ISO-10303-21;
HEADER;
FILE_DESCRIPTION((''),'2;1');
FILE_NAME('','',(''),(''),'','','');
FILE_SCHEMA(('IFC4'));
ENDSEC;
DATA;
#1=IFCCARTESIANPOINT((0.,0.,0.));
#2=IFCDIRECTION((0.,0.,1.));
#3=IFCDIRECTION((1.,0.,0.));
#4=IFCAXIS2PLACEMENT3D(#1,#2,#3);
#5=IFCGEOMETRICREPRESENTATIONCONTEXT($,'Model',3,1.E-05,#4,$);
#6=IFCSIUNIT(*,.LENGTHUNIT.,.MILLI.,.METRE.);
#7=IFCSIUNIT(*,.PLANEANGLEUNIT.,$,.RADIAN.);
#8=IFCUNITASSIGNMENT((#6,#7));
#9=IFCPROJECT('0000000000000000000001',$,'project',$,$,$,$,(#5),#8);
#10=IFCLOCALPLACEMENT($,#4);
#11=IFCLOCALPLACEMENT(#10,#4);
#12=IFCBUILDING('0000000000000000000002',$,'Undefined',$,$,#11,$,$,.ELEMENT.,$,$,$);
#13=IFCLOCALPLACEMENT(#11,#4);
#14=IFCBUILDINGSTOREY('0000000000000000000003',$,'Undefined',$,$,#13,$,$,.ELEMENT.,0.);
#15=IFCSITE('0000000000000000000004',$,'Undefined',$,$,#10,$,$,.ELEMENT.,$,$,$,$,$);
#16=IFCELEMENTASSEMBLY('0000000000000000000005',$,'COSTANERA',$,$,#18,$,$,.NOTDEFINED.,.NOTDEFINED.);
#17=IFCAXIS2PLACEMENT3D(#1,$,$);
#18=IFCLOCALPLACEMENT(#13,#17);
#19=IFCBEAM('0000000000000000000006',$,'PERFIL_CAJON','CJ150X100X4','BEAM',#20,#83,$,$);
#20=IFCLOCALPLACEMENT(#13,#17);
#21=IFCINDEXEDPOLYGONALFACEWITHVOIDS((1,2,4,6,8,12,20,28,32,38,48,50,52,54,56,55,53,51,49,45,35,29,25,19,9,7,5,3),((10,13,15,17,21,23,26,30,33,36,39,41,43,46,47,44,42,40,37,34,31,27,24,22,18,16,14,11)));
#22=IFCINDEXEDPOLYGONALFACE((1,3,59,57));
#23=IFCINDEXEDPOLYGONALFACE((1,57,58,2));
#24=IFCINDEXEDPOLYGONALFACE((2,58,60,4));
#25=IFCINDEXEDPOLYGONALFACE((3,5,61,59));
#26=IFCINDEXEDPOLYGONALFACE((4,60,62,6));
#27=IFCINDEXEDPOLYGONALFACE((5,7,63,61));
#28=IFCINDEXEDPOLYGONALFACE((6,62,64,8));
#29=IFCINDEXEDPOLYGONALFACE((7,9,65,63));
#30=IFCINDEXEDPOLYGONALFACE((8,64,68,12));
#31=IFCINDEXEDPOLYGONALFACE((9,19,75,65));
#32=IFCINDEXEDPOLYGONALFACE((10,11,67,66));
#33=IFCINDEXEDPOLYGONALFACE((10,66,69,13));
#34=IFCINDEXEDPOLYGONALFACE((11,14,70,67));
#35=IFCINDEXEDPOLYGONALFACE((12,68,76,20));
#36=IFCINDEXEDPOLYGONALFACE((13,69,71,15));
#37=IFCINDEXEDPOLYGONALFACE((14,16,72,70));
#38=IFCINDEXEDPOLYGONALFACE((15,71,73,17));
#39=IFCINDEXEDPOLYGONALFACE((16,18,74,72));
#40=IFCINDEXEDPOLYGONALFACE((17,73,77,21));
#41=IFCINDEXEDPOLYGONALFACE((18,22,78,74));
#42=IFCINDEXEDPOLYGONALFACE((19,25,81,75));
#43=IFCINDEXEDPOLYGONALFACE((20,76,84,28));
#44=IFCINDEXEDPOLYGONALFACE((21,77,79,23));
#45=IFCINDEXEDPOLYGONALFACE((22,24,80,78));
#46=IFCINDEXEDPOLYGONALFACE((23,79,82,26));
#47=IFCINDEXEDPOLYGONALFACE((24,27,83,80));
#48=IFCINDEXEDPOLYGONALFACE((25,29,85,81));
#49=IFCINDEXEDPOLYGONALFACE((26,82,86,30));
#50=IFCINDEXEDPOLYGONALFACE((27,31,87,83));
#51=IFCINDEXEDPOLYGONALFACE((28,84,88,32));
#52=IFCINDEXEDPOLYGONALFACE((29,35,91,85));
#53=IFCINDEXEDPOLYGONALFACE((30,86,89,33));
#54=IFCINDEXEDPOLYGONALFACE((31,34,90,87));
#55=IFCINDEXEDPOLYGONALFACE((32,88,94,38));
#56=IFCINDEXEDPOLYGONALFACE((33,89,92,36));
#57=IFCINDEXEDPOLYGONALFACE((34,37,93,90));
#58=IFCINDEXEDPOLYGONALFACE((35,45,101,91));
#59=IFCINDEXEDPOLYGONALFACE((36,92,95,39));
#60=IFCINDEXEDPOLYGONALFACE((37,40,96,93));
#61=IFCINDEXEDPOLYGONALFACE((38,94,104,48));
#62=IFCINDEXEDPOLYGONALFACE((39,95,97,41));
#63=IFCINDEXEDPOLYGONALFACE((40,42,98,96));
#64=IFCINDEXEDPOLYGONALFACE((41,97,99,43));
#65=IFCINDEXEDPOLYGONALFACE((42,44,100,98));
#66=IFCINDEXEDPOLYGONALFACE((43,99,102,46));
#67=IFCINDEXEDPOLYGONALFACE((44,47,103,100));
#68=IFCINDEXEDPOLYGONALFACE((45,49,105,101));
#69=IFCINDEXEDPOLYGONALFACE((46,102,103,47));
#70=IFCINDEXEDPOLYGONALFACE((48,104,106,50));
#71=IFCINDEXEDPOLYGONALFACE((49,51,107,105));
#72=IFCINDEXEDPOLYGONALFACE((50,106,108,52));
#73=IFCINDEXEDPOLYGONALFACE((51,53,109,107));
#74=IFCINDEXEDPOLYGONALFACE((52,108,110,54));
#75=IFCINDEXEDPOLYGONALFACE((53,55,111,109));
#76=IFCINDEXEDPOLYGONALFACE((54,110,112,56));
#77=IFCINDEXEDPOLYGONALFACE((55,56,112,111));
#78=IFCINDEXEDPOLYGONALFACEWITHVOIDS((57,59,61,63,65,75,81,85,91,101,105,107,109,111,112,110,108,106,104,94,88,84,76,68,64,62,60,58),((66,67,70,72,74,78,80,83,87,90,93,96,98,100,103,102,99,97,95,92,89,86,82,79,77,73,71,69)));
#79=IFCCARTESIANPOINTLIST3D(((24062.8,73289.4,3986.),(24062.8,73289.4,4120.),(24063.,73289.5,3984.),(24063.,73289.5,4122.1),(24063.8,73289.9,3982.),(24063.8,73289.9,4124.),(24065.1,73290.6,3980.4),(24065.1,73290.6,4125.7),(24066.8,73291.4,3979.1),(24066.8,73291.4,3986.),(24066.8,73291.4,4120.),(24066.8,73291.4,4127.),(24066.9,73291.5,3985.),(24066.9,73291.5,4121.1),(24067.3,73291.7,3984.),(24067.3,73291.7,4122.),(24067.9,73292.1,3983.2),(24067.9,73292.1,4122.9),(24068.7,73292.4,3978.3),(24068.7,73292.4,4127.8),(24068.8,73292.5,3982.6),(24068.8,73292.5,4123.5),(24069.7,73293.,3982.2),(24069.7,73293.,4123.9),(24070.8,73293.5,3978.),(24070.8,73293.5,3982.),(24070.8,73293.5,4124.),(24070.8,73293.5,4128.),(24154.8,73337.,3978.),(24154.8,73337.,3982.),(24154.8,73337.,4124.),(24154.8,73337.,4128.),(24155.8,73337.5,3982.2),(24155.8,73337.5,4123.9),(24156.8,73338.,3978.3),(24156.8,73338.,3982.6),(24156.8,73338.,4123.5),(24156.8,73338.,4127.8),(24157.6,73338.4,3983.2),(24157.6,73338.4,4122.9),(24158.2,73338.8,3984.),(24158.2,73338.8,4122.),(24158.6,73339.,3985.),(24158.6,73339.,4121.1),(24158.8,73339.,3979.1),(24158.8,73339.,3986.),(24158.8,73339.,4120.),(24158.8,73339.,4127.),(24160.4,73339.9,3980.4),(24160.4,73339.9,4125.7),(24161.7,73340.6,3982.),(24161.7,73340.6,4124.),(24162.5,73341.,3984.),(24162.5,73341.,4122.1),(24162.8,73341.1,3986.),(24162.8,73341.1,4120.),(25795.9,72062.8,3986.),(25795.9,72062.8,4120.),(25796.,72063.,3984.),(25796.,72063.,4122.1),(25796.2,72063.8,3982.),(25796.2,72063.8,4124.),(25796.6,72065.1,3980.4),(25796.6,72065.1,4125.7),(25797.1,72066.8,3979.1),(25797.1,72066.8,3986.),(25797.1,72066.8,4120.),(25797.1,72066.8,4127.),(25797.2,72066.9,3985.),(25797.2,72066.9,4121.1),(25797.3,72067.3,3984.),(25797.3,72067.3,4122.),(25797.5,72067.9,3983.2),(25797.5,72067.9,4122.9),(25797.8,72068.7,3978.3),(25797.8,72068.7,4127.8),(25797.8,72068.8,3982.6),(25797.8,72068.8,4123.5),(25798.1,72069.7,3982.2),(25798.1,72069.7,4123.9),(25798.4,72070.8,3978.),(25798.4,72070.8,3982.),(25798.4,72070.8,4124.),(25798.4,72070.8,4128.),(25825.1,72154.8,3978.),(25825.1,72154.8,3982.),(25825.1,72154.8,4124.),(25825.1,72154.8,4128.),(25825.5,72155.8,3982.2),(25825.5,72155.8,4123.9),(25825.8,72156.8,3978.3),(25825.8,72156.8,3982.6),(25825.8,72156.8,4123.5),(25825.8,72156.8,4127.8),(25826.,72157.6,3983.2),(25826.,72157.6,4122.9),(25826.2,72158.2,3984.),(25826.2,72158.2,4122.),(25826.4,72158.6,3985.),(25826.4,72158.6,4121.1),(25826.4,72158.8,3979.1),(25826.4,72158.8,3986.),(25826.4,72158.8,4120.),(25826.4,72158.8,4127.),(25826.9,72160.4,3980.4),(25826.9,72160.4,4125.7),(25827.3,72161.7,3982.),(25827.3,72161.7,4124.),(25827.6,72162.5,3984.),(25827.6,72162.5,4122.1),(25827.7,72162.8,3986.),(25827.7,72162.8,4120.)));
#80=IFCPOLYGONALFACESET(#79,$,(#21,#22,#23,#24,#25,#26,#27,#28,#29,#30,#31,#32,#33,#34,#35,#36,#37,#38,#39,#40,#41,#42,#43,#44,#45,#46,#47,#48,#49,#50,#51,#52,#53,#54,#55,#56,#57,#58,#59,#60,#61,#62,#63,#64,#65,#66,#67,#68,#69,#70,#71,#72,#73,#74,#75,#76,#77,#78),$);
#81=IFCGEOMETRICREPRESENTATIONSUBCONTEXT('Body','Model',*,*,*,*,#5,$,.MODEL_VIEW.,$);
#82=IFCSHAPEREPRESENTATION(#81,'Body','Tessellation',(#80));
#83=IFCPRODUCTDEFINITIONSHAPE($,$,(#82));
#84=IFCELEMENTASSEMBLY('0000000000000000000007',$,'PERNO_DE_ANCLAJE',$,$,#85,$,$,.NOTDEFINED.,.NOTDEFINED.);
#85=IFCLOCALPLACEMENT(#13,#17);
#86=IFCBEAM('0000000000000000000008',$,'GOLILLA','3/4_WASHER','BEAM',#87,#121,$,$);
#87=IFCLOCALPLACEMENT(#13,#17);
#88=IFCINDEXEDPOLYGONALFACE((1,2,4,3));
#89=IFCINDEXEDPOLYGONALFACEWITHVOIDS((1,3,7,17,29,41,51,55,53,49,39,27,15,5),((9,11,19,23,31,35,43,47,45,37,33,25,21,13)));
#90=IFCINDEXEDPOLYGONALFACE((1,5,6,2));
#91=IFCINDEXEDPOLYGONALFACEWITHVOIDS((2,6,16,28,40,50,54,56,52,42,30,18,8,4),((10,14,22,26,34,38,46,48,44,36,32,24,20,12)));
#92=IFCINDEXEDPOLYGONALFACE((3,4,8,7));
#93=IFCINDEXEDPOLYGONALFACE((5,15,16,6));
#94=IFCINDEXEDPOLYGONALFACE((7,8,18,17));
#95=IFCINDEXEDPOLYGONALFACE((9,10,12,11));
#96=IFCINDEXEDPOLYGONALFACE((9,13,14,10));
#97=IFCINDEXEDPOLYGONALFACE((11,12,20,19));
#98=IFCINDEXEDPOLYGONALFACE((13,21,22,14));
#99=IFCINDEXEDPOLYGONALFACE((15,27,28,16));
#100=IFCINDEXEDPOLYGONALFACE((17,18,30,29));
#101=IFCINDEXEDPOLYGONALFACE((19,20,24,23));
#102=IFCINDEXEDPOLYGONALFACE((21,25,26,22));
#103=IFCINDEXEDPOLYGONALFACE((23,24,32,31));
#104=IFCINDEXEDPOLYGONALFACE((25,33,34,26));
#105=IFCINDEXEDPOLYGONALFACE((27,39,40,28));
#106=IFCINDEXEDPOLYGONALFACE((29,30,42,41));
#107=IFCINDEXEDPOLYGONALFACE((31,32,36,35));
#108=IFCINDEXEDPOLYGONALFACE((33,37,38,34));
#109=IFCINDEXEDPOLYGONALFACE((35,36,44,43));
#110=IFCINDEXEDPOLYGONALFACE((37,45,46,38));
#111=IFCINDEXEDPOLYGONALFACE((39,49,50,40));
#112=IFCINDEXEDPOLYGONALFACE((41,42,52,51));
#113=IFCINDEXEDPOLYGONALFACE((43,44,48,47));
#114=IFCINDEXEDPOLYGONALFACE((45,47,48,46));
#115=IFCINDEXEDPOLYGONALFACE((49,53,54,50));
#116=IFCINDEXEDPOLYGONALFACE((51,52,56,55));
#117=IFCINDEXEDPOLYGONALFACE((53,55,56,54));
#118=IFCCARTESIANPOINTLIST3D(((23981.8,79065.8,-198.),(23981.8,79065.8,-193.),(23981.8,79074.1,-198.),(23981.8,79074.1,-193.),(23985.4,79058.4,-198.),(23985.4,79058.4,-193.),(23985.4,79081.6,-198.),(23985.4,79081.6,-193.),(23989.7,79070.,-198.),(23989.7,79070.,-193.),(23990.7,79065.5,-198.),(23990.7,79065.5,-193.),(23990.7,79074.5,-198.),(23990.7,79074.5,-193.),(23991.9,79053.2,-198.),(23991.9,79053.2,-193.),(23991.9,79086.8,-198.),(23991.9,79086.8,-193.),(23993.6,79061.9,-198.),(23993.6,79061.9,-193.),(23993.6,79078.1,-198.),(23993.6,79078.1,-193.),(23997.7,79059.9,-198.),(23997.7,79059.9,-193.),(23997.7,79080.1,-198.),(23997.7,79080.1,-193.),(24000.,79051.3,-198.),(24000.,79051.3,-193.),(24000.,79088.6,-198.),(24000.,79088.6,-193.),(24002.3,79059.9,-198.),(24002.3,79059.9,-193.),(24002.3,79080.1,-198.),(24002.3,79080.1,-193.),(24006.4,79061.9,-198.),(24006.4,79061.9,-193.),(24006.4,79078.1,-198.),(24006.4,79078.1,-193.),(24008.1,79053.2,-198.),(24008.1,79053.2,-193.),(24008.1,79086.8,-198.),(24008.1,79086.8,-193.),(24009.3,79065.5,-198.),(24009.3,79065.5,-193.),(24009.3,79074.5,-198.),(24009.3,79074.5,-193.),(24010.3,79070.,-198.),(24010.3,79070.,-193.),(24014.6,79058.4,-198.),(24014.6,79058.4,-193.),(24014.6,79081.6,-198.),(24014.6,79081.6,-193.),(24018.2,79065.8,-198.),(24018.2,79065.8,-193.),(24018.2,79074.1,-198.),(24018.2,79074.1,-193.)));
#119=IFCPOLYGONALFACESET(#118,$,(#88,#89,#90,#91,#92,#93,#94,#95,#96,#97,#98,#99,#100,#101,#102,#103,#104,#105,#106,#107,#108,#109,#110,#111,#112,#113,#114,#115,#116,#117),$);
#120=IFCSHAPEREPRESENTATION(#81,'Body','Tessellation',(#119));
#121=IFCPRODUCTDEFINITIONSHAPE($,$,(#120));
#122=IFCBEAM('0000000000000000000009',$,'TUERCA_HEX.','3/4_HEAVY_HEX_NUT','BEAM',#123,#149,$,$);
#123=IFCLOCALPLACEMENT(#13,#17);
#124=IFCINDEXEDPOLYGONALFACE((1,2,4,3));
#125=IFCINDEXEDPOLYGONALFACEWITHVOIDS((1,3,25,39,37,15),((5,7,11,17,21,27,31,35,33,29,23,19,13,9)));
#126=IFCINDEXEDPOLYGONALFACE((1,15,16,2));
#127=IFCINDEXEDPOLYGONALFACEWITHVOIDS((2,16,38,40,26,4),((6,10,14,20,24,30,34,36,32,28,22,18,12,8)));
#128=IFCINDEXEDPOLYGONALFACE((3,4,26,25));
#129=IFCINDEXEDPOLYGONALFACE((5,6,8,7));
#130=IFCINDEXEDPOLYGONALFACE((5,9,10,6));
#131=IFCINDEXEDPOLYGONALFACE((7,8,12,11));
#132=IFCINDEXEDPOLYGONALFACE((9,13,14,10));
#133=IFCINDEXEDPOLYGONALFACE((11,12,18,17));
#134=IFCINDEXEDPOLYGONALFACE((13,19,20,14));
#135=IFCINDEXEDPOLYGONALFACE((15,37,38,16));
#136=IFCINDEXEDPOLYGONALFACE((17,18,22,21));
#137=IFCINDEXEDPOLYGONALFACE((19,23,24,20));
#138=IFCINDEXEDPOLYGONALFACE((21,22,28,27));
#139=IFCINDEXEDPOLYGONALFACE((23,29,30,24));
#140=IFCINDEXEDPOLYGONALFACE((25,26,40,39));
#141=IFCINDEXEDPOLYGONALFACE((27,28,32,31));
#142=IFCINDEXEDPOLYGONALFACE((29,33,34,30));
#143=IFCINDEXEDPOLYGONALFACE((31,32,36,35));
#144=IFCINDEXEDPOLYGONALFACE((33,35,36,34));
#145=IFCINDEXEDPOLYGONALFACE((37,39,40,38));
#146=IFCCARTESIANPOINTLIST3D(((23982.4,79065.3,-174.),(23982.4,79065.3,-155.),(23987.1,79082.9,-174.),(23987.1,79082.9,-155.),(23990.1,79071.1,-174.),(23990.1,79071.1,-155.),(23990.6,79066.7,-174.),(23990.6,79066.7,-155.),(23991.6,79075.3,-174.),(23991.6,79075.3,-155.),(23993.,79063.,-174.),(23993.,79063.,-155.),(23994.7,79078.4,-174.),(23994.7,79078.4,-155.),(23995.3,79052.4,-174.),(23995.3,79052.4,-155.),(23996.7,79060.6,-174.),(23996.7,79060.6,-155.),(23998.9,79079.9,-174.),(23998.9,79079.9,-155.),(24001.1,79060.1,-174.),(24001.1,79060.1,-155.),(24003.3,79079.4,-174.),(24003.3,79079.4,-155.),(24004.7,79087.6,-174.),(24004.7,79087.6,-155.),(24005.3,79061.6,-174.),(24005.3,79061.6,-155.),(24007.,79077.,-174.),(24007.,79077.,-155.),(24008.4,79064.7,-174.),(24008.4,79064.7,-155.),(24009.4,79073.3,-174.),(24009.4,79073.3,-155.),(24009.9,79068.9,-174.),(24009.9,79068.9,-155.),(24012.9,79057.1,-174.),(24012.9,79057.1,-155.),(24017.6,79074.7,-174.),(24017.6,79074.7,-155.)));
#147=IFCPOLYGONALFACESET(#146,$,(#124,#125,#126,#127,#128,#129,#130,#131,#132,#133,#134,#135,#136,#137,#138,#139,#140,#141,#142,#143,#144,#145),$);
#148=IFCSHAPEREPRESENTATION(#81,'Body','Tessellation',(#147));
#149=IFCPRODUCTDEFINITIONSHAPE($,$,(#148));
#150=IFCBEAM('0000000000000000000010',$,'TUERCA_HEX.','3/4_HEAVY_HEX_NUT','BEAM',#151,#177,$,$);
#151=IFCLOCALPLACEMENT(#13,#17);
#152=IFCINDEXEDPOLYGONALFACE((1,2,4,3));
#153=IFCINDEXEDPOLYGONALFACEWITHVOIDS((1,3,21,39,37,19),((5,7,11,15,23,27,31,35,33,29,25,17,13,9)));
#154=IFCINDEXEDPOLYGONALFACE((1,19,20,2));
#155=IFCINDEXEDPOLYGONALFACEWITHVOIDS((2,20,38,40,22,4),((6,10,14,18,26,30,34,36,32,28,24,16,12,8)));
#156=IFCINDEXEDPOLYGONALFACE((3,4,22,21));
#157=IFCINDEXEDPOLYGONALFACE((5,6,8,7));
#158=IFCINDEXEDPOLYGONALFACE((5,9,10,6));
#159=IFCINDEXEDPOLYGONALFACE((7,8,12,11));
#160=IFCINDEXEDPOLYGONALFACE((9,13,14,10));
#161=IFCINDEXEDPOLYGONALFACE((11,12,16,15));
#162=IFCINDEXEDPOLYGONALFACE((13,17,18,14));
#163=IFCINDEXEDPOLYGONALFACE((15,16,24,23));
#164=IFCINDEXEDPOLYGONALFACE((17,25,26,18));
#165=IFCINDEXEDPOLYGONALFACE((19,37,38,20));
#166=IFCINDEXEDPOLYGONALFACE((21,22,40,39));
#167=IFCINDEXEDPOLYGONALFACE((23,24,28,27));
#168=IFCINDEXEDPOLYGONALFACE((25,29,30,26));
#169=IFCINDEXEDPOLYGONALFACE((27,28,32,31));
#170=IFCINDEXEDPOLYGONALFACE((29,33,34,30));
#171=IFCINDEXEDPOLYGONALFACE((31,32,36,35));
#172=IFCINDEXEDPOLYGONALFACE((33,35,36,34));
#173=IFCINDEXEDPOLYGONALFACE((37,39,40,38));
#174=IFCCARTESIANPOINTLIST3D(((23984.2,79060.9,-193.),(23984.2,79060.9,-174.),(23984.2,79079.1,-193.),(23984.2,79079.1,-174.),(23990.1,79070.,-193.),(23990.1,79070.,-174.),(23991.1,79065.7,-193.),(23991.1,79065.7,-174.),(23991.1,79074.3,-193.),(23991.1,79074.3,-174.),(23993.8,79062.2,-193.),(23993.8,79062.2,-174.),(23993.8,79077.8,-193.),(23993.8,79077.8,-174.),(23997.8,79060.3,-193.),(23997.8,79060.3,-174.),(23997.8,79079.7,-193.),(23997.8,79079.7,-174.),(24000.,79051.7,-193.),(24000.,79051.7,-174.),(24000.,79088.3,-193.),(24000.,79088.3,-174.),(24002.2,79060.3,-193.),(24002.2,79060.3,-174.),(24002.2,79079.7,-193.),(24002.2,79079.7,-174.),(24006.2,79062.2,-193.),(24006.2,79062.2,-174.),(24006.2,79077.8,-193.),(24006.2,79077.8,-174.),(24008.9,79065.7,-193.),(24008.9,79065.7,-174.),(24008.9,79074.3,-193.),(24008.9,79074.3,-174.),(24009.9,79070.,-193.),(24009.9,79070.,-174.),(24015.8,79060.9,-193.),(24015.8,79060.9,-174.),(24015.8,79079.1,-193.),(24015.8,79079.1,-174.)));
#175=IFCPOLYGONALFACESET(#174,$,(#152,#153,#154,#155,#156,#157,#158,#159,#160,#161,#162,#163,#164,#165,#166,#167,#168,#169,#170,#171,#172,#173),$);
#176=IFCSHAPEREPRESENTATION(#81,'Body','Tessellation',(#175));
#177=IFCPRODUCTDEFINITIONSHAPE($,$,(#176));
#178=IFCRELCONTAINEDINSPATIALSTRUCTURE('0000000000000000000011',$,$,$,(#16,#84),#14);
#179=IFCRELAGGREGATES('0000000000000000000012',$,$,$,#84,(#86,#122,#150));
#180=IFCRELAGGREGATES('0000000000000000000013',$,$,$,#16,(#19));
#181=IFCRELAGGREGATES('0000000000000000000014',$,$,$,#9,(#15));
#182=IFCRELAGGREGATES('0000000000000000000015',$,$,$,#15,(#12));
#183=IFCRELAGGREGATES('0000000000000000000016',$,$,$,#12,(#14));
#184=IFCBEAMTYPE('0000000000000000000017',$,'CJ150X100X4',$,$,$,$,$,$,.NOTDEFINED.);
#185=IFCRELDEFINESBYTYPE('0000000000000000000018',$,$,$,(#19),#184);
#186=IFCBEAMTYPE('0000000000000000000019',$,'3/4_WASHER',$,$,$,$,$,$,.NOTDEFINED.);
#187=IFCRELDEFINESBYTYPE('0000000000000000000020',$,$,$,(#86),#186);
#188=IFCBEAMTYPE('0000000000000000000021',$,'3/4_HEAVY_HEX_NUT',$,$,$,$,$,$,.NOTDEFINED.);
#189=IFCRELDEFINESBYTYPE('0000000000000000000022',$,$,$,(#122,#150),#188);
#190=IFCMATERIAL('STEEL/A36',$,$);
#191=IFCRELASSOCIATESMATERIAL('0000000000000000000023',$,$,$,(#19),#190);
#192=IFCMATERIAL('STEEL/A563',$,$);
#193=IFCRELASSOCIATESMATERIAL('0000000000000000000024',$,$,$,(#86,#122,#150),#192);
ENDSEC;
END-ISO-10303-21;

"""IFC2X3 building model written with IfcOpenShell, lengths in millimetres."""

from ifc_helpers import new_model, si_unit, frame, origin_with_axes, origin_2d_with_axis, place, context, subcontext, project, spatial, polyline, hollow_rectangle, outline, extrude, clip, halfspace, material, type_object, element, aggregate, save


model = new_model("IFC2X3")

# Units and contexts
model_context = context("Model", 3, precision=1e-05, world=origin_with_axes())
body_context = subcontext(model_context, "Body", "Model", "MODEL_VIEW")
ifc_project = project(units=[si_unit("LENGTHUNIT", "METRE", prefix="MILLI"), si_unit("PLANEANGLEUNIT", "RADIAN")], contexts=[model_context])

# Site, building, storey
site_placement = place(None, origin_with_axes())
site = spatial("IfcSite", under=ifc_project, at=site_placement, Name="Undefined", CompositionType="ELEMENT")
building_placement = place(site_placement, origin_with_axes())
building = spatial("IfcBuilding", under=site, at=building_placement, Name="Undefined", CompositionType="ELEMENT")
storey_placement = place(building_placement, origin_with_axes())
storey = spatial("IfcBuildingStorey", under=building, at=storey_placement, Name="Undefined", CompositionType="ELEMENT", Elevation=0.0)

# Shared definitions
ifc_material_1 = material(Name="STEEL/A36")
beam_type_1 = type_object("IfcBeamType", Name="CJ150X100X4", PredefinedType="NOTDEFINED")

# Element assemblies, beams
assembly_1_placement = place(storey_placement, origin_with_axes())
assembly_1 = element("IfcElementAssembly", 1, at=assembly_1_placement, inside=storey, Name="COSTANERA", AssemblyPlace="NOTDEFINED", PredefinedType="NOTDEFINED")
beam_1_placement = place(assembly_1_placement, frame((24112.8, 73315.2, 4053.0), z_axis=(0.0, 0.0, 1.0), x_axis=(0.816249, -0.577701, 0.0)))
beam_1 = element("IfcBeam", 2, at=beam_1_placement, type_object=beam_type_1, material=ifc_material_1, Name="PERFIL_CAJON", Description="CJ150X100X4", ObjectType="BEAM", context=body_context, shape_type="Clipping", body=[
    clip(clip(extrude(hollow_rectangle(XDim=100.0, YDim=150.0, WallThickness=4.0, InnerFilletRadius=4.0, OuterFilletRadius=8.0, at=origin_2d_with_axis()), frame((2180.1, 0.0, 0.0), z_axis=(-1.0, 0.0, 0.0), x_axis=(0.0, -1.0, 0.0)), (0.0, 0.0, 1.0), 2278.7), halfspace(frame((2065.6, 50.0, 0.0), z_axis=(-0.952956, -0.30311, 0.0), x_axis=(0.0, 0.0, 1.0)), True)), halfspace(frame((-25.9, -50.0, 0.0), z_axis=(0.888173, -0.45951, 0.0), x_axis=(0.0, 0.0, 1.0)), True)),
])
assembly_2_placement = place(storey_placement, origin_with_axes())
assembly_2 = element("IfcElementAssembly", 3, at=assembly_2_placement, inside=storey, Name="PERNO_DE_ANCLAJE", AssemblyPlace="NOTDEFINED", PredefinedType="NOTDEFINED")
ifc_material_2 = material(Name="STEEL/A563")
beam_type_2 = type_object("IfcBeamType", Name="3/4_WASHER", PredefinedType="NOTDEFINED")
beam_2_placement = place(assembly_2_placement, frame((24000.0, 79070.0, -193.0), z_axis=(1.0, 0.0, 0.0), x_axis=(0.0, 0.00008, -1.0)))
beam_2 = element("IfcBeam", 4, at=beam_2_placement, type_object=beam_type_2, material=ifc_material_2, Name="GOLILLA", Description="3/4_WASHER", ObjectType="BEAM", context=body_context, shape_type="SweptSolid", body=[
    extrude(outline(polyline([(-16.8, 8.1), (-11.6, 14.6), (-4.2, 18.2), (4.2, 18.2), (11.6, 14.6), (16.8, 8.1), (18.6, 0.0), (16.8, -8.1), (11.6, -14.6), (4.2, -18.2), (-4.2, -18.2), (-11.6, -14.6), (-16.8, -8.1), (-18.6, 0.0), (-16.8, 8.1)]), holes=[polyline([(8.1, 6.4), (4.5, 9.3), (0.0, 10.3), (-4.5, 9.3), (-8.1, 6.4), (-10.1, 2.3), (-10.1, -2.3), (-8.1, -6.4), (-4.5, -9.3), (0.0, -10.3), (4.5, -9.3), (8.1, -6.4), (10.1, -2.3), (10.1, 2.3), (8.1, 6.4)])]), frame((5.0, 0.0, 0.0), z_axis=(-1.0, 0.0, 0.0), x_axis=(0.0, -1.0, 0.0)), (0.0, 0.0, 1.0), 5.0),
])
beam_type_3 = type_object("IfcBeamType", Name="3/4_HEAVY_HEX_NUT", PredefinedType="NOTDEFINED")
beam_3_placement = place(assembly_2_placement, frame((24000.0, 79070.0, -155.0), z_axis=(0.707107, 0.707107, 0.0), x_axis=(0.0, 0.0, -1.0)))
beam_3 = element("IfcBeam", 5, at=beam_3_placement, type_object=beam_type_3, material=ifc_material_2, Name="TUERCA_HEX.", Description="3/4_HEAVY_HEX_NUT", ObjectType="BEAM", context=body_context, shape_type="SweptSolid", body=[
    extrude(outline(polyline([(-9.1, -15.8), (-18.3, 0.0), (-9.1, 15.8), (9.1, 15.8), (18.3, 0.0), (9.1, -15.8), (-9.1, -15.8)]), holes=[polyline([(7.8, 6.2), (4.3, 8.9), (0.0, 9.9), (-4.3, 8.9), (-7.8, 6.2), (-9.7, 2.2), (-9.7, -2.2), (-7.8, -6.2), (-4.3, -8.9), (0.0, -9.9), (4.3, -8.9), (7.8, -6.2), (9.7, -2.2), (9.7, 2.2), (7.8, 6.2)])]), frame((19.0, 0.0, 0.0), z_axis=(-1.0, 0.0, 0.0), x_axis=(0.0, -1.0, 0.0)), (0.0, 0.0, 1.0), 19.0),
])
beam_4_placement = place(assembly_2_placement, frame((24000.0, 79070.0, -174.0), z_axis=(1.0, 0.0, 0.0), x_axis=(0.0, 0.0, -1.0)))
beam_4 = element("IfcBeam", 6, at=beam_4_placement, type_object=beam_type_3, material=ifc_material_2, Name="TUERCA_HEX.", Description="3/4_HEAVY_HEX_NUT", ObjectType="BEAM", context=body_context, shape_type="SweptSolid", body=[
    extrude(outline(polyline([(-9.1, -15.8), (-18.3, 0.0), (-9.1, 15.8), (9.1, 15.8), (18.3, 0.0), (9.1, -15.8), (-9.1, -15.8)]), holes=[polyline([(7.8, 6.2), (4.3, 8.9), (0.0, 9.9), (-4.3, 8.9), (-7.8, 6.2), (-9.7, 2.2), (-9.7, -2.2), (-7.8, -6.2), (-4.3, -8.9), (0.0, -9.9), (4.3, -8.9), (7.8, -6.2), (9.7, -2.2), (9.7, 2.2), (7.8, 6.2)])]), frame((19.0, 0.0, 0.0), z_axis=(-1.0, 0.0, 0.0), x_axis=(0.0, -1.0, 0.0)), (0.0, 0.0, 1.0), 19.0),
])
aggregate(assembly_2, [beam_2, beam_3, beam_4])

aggregate(assembly_1, [beam_1])

save(model, "model.ifc")
